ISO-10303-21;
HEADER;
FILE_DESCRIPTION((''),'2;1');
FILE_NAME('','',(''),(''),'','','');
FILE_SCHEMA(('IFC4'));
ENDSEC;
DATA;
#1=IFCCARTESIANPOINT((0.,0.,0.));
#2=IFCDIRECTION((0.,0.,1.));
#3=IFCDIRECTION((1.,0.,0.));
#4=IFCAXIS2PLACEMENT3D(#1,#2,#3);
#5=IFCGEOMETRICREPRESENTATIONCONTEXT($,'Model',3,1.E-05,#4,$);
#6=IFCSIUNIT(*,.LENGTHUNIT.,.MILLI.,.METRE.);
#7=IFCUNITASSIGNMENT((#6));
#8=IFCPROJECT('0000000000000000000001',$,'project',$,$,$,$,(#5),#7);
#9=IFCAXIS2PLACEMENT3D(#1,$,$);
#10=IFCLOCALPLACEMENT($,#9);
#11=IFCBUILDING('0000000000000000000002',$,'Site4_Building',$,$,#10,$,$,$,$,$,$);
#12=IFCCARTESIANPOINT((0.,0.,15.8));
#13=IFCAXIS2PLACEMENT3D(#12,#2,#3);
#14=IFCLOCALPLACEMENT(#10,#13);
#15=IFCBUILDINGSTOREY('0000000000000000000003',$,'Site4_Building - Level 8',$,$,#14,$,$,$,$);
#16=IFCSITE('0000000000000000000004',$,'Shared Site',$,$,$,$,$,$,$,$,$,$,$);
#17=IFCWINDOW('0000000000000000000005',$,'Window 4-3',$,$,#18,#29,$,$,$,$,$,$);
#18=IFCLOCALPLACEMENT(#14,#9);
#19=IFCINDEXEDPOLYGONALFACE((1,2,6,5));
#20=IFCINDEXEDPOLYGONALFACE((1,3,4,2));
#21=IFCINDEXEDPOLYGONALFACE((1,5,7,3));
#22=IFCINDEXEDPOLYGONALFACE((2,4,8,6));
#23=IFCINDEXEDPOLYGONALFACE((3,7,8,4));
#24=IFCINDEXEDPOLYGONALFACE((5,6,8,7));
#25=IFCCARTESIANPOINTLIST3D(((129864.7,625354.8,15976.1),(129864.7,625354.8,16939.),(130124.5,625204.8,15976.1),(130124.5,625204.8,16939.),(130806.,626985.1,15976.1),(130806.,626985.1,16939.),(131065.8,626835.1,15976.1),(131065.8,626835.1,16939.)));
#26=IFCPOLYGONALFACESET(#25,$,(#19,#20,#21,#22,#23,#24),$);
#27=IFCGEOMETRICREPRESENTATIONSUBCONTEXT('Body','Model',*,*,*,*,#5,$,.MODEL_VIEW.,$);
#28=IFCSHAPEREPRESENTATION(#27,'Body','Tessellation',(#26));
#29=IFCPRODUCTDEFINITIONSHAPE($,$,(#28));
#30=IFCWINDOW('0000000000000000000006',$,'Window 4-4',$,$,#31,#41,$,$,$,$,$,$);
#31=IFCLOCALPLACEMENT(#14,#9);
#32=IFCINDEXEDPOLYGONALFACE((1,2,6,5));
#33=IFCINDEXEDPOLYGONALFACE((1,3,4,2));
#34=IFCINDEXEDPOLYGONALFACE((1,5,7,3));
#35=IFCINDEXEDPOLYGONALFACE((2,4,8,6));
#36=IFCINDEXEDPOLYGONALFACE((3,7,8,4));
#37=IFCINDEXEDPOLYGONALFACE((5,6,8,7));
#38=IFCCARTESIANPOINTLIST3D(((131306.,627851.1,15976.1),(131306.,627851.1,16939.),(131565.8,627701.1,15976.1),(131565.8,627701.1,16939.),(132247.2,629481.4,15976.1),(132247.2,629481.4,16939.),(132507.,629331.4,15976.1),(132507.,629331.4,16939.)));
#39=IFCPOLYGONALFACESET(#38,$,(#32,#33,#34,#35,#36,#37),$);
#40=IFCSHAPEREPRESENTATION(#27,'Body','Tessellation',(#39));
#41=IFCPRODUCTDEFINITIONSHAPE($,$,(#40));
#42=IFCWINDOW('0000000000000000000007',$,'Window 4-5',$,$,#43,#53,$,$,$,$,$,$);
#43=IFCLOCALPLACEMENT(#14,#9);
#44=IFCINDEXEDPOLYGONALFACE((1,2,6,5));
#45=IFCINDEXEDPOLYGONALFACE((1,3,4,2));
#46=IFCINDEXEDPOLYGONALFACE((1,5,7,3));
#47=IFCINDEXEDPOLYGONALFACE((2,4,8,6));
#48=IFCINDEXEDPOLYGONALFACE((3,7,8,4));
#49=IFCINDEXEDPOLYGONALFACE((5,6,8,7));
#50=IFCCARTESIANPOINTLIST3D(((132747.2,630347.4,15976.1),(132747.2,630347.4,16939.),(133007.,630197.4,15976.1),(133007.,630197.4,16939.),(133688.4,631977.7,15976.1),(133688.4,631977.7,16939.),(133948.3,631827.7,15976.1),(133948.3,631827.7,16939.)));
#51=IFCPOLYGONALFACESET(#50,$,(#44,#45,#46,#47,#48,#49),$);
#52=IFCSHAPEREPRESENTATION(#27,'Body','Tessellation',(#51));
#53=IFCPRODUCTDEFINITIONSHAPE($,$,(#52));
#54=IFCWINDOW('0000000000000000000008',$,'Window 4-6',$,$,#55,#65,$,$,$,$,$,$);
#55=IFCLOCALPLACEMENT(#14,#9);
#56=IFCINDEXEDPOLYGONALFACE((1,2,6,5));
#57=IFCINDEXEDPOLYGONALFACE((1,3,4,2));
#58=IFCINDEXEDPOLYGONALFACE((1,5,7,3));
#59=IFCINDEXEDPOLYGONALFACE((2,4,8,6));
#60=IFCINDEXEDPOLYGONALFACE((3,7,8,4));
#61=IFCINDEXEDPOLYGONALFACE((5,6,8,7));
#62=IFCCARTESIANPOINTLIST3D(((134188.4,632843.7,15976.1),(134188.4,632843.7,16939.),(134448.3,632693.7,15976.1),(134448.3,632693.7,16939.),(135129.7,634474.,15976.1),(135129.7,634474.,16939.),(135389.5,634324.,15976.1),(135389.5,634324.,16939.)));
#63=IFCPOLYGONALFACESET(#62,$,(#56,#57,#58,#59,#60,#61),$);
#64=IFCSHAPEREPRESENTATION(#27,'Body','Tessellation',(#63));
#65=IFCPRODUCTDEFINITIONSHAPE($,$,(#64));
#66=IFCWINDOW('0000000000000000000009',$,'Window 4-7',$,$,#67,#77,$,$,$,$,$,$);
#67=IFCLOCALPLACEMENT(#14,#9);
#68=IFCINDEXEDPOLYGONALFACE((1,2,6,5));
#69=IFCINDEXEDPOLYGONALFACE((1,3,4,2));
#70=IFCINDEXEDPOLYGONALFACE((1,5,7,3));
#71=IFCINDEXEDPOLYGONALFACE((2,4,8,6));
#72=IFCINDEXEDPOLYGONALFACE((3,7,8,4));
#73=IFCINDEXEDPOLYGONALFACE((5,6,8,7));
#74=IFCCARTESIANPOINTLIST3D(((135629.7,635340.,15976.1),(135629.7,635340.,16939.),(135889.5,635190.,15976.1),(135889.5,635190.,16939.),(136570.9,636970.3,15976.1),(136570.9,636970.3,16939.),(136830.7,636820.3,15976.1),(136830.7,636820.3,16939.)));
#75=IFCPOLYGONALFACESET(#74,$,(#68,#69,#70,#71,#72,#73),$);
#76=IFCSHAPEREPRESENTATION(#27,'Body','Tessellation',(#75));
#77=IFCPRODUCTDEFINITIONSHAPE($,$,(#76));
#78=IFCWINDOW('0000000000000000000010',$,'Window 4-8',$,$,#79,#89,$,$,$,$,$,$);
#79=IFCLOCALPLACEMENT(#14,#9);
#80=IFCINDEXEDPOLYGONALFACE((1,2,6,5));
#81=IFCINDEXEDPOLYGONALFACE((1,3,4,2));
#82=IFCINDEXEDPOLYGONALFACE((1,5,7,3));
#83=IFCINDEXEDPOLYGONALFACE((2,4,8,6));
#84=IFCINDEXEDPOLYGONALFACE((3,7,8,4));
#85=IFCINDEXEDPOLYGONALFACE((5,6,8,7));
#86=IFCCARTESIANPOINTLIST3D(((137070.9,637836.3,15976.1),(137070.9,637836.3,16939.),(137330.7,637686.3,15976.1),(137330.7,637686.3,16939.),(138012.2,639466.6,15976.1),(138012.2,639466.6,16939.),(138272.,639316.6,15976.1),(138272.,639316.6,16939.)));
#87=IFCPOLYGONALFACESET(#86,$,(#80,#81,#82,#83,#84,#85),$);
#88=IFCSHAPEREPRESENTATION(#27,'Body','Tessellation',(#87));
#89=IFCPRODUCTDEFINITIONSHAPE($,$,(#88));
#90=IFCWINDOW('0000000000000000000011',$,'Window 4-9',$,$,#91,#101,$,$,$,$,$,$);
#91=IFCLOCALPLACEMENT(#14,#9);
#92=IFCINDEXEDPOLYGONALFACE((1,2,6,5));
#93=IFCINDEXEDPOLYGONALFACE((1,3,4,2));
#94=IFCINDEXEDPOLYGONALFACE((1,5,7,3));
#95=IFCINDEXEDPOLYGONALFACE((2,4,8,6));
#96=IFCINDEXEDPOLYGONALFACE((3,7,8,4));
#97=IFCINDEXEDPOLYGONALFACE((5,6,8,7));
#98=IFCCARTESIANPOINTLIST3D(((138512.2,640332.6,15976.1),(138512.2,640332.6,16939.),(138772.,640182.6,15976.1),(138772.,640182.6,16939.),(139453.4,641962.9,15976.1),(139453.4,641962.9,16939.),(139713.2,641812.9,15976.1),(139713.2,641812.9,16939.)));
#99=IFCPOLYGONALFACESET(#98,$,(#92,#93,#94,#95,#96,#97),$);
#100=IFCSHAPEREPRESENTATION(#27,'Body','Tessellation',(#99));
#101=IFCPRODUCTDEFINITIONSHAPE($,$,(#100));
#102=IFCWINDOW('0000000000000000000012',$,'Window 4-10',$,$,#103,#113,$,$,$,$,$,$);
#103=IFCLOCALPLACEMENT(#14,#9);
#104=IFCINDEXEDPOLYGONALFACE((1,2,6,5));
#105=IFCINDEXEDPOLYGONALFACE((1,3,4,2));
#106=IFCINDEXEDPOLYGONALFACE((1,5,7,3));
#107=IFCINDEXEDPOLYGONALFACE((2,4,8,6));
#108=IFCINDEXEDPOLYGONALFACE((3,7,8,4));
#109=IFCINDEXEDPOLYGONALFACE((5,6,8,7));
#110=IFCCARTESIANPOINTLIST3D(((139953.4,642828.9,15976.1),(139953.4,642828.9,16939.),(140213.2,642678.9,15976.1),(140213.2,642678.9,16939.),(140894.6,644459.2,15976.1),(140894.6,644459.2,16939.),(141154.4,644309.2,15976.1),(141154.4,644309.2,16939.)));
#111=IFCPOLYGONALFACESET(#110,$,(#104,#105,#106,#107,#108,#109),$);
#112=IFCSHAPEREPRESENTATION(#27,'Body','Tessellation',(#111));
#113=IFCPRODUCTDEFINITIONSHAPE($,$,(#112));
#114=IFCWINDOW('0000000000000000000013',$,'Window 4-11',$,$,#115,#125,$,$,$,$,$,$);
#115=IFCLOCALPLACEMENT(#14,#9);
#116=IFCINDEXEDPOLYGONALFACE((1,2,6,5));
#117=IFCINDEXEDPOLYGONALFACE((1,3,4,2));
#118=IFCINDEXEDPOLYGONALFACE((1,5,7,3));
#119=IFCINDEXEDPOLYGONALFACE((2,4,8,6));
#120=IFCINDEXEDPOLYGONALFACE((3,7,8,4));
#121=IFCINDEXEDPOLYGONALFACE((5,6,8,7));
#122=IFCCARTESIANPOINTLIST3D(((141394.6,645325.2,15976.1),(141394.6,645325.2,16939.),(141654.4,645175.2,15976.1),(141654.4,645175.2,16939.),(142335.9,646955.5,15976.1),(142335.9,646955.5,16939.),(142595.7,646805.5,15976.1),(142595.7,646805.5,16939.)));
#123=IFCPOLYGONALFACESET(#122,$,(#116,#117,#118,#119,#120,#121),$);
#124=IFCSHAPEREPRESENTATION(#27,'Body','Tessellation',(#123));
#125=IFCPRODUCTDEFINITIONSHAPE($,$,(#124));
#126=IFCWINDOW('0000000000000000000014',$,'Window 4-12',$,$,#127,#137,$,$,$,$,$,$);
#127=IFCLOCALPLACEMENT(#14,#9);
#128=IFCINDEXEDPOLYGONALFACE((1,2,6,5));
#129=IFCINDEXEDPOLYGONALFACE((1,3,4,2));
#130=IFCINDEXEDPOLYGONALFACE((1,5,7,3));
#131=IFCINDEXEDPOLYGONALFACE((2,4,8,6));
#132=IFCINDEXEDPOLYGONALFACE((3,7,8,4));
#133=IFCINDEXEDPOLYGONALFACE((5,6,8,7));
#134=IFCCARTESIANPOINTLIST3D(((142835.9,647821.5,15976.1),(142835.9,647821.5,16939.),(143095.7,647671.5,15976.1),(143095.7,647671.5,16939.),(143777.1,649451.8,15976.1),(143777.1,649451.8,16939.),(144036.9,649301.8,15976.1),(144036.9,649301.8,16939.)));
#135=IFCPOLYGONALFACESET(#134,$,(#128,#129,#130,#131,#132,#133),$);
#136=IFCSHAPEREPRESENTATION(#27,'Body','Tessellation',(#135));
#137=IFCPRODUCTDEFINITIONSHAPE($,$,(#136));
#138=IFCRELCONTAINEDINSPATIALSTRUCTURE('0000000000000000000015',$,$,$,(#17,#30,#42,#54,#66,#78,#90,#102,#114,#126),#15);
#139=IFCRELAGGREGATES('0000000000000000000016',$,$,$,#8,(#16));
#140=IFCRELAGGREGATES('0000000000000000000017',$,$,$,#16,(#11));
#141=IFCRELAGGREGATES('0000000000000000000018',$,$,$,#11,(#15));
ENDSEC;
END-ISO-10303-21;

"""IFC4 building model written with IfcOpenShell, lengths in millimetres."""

from ifc_helpers import new_model, si_unit, frame, origin, origin_with_axes, place, context, subcontext, project, spatial, indexed_curve, outline, extrude, element, save


model = new_model("IFC4")

# Units and contexts
model_context = context("Model", 3, precision=1e-05, world=origin_with_axes())
body_context = subcontext(model_context, "Body", "Model", "MODEL_VIEW")
ifc_project = project(units=[si_unit("LENGTHUNIT", "METRE", prefix="MILLI")], contexts=[model_context])

# Site, building, storey
site = spatial("IfcSite", under=ifc_project, Name="Shared Site")
building_placement = place(None, origin())
building = spatial("IfcBuilding", under=site, at=building_placement, Name="Site4_Building")
storey_placement = place(building_placement, frame((0.0, 0.0, 15.8), z_axis=(0.0, 0.0, 1.0), x_axis=(1.0, 0.0, 0.0)))
storey = spatial("IfcBuildingStorey", under=building, at=storey_placement, Name="Site4_Building - Level 8")

# Windows
for number, where, z_axis, x_axis, name in (
    (1, (130124.5, 625204.8, 15976.1), (0.0, 0.0, 1.0), (0.5, 0.866025, 0.0), "Window 4-3"),
    (2, (131565.8, 627701.1, 15976.1), (0.0, 0.0, 1.0), (0.5, 0.866025, 0.0), "Window 4-4"),
    (3, (133007.0, 630197.4, 15976.1), (0.0, 0.0, 1.0), (0.5, 0.866025, 0.0), "Window 4-5"),
    (4, (134448.3, 632693.7, 15976.1), (0.0, 0.0, 1.0), (0.5, 0.866025, 0.0), "Window 4-6"),
    (5, (135889.5, 635190.0, 15976.1), (0.0, 0.0, 1.0), (0.5, 0.866025, 0.0), "Window 4-7"),
    (6, (137330.7, 637686.3, 15976.1), (0.0, 0.0, 1.0), (0.5, 0.866025, 0.0), "Window 4-8"),
    (7, (138772.0, 640182.6, 15976.1), (0.0, 0.0, 1.0), (0.5, 0.866025, 0.0), "Window 4-9"),
    (8, (140213.2, 642678.9, 15976.1), (0.0, 0.0, 1.0), (0.5, 0.866025, 0.0), "Window 4-10"),
    (9, (141654.4, 645175.2, 15976.1), (0.0, 0.0, 1.0), (0.5, 0.866025, 0.0), "Window 4-11"),
    (10, (143095.7, 647671.5, 15976.1), (0.0, 0.0, 1.0), (0.5, 0.866025, 0.0), "Window 4-12"),
):
    element("IfcWindow", number, at=place(storey_placement, frame(where, z_axis=z_axis, x_axis=x_axis)), inside=storey, Name=name, context=body_context, shape_type="SweptSolid", body=[
        extrude(outline(indexed_curve([(0.0, 0.0), (0.0, 300.0), (1882.5, 300.0), (1882.5, 0.0), (0.0, 0.0)], self_intersect=False)), origin_with_axes(), (0.0, 0.0, 1.0), 962.8),
    ])

save(model, "model.ifc")
